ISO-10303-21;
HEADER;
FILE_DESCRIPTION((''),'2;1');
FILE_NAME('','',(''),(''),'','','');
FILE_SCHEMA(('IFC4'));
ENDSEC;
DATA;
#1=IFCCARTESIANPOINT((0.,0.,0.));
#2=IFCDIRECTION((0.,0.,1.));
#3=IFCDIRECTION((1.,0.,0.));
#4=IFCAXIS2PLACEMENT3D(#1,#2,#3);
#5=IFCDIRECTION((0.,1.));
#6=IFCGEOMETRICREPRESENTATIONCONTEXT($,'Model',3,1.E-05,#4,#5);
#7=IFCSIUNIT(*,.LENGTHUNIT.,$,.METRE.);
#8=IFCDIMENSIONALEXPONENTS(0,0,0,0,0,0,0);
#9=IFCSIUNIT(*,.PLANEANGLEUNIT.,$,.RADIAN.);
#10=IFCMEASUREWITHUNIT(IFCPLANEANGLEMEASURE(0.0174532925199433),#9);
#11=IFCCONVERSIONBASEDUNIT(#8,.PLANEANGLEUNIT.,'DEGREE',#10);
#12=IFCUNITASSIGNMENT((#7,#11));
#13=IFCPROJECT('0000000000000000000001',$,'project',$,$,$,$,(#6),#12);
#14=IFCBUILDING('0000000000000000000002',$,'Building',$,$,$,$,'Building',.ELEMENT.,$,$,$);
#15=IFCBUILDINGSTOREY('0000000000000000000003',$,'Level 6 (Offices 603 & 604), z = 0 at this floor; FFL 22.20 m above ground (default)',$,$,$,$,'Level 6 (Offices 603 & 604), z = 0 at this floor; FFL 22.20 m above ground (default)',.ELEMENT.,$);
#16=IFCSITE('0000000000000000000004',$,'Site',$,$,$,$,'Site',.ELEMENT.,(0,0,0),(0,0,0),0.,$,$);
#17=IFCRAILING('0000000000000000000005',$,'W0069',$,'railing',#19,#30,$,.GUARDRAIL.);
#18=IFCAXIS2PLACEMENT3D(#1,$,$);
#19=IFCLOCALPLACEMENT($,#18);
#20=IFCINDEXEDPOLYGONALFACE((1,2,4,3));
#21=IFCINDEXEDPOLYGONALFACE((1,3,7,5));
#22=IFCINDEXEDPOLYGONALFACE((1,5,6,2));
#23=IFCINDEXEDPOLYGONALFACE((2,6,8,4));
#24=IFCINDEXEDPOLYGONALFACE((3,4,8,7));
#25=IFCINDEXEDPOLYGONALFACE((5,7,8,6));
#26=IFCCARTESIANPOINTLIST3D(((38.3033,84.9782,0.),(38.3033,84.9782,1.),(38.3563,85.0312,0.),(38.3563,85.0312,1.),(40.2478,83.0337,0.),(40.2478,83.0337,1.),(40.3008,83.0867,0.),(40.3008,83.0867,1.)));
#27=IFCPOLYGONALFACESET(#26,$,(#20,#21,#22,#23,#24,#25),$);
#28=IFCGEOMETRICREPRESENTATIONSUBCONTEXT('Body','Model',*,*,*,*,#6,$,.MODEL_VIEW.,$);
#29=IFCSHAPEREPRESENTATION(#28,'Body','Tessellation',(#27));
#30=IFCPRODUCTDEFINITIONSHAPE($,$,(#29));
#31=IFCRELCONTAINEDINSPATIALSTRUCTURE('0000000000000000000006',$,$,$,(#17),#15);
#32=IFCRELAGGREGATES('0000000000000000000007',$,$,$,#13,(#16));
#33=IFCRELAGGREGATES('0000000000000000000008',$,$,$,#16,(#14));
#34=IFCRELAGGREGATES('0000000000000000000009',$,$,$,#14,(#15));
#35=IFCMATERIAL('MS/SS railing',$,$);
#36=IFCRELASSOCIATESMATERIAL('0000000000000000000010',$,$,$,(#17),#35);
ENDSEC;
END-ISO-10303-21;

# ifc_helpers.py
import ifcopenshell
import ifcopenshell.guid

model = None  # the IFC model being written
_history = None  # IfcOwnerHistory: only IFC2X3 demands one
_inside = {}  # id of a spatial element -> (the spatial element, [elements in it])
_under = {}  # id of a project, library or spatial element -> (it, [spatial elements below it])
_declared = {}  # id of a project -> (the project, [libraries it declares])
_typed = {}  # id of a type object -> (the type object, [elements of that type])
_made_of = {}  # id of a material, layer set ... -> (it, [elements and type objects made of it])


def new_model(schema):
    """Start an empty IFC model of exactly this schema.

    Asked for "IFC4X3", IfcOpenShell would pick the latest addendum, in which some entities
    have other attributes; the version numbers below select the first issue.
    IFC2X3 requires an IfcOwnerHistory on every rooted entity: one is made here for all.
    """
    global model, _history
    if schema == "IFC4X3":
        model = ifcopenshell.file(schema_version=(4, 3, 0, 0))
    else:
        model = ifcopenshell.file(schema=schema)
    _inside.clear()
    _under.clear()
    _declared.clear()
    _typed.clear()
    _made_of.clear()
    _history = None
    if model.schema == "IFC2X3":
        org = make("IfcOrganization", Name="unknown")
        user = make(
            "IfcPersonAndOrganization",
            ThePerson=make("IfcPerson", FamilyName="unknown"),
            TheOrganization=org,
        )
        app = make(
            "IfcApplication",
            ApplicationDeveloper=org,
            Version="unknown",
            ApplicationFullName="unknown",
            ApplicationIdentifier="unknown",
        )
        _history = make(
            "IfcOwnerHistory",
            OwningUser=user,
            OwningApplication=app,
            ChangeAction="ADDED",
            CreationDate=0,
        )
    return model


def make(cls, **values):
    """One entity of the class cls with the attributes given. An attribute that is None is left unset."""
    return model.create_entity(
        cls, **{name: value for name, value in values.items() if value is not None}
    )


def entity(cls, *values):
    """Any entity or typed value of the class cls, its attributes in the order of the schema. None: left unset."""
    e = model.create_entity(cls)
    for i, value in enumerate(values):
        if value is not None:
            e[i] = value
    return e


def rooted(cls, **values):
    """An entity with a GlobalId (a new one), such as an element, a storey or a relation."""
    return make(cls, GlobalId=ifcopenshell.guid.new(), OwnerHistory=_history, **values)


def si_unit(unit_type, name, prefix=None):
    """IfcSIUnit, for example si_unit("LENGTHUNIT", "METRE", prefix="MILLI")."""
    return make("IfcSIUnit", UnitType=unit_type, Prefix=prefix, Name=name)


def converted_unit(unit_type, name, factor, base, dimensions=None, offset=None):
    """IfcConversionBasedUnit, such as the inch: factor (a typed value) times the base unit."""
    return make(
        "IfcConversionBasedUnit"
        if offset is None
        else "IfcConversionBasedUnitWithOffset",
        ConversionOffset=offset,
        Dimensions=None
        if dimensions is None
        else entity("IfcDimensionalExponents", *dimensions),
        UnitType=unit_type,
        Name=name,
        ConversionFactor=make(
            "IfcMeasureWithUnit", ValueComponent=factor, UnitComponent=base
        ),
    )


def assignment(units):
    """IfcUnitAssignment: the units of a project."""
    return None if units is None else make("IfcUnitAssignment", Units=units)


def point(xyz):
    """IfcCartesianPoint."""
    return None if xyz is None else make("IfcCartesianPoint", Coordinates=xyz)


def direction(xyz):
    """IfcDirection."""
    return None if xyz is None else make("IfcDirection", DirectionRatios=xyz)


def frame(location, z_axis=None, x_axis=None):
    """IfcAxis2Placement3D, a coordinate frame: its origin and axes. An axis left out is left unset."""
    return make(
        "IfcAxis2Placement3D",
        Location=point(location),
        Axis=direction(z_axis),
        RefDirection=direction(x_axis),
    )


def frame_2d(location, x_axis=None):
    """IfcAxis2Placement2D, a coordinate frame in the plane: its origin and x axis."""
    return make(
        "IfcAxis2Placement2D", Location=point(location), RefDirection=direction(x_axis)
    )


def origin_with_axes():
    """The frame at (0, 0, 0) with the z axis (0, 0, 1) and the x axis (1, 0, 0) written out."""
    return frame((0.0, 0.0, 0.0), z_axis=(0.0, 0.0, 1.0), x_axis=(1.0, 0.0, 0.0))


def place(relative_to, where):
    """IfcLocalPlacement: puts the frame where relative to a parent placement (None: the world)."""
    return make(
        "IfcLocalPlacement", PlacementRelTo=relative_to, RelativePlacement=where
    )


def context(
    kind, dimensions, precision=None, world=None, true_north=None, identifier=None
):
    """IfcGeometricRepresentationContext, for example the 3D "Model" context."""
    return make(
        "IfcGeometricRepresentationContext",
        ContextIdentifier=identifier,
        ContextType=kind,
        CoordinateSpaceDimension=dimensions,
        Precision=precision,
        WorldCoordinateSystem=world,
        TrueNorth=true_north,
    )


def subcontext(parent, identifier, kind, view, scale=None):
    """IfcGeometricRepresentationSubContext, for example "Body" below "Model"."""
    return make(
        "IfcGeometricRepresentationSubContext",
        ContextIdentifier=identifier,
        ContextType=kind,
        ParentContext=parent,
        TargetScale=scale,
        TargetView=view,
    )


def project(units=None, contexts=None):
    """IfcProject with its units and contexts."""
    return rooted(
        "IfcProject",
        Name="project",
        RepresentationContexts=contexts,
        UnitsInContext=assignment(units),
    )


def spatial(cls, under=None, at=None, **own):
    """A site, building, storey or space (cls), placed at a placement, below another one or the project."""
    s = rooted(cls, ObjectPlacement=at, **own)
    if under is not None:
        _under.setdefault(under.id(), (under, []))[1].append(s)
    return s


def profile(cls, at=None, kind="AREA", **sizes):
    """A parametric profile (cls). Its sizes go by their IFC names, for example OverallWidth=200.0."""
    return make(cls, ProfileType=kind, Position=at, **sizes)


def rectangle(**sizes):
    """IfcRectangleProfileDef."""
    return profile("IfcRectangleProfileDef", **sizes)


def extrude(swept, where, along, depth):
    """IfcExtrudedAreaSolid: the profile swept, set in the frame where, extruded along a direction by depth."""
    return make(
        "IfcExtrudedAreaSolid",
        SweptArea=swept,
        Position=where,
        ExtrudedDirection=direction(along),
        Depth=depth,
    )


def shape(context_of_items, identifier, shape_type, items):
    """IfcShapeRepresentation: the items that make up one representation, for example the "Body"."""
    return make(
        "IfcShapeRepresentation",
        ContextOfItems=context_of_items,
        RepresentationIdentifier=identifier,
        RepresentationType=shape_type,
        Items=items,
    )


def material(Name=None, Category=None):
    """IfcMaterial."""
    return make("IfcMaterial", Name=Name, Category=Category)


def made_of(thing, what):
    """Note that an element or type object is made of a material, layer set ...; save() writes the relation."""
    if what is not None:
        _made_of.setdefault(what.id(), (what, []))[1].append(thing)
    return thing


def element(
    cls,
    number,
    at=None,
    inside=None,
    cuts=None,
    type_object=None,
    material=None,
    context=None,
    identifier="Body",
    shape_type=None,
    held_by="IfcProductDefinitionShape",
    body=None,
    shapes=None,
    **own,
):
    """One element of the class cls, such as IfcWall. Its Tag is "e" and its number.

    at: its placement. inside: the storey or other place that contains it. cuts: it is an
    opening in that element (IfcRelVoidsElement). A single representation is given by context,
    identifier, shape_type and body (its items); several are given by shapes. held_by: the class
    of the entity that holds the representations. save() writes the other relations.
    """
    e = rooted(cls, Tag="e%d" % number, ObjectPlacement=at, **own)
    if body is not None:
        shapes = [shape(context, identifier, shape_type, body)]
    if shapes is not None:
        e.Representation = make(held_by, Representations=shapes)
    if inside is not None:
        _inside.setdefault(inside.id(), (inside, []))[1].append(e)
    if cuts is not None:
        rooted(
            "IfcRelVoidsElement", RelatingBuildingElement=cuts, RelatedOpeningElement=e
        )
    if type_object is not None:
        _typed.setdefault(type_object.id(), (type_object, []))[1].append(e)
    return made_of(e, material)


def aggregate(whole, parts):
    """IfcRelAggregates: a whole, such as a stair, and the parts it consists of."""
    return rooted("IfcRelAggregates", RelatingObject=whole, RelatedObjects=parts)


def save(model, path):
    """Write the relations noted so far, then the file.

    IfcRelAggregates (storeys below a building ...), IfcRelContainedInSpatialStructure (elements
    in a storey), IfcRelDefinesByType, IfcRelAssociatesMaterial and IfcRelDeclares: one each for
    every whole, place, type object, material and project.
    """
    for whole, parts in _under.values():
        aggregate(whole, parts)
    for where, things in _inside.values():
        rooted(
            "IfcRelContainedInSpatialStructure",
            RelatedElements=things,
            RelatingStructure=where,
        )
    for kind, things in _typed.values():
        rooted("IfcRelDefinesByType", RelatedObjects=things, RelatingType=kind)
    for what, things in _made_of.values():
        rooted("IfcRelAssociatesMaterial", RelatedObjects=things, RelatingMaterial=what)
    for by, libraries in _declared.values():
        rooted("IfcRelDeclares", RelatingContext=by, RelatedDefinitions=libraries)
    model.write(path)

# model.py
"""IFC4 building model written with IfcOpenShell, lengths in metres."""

from ifc_helpers import new_model, entity, si_unit, converted_unit, direction, frame, frame_2d, origin_with_axes, place, context, subcontext, project, spatial, rectangle, extrude, material, element, save


model = new_model("IFC4")

# Units and contexts
model_context = context("Model", 3, precision=1e-05, world=origin_with_axes(), true_north=direction((0.0, 1.0)))
body_context = subcontext(model_context, "Body", "Model", "MODEL_VIEW")
ifc_project = project(units=[si_unit("LENGTHUNIT", "METRE"), converted_unit("PLANEANGLEUNIT", "DEGREE", entity("IfcPlaneAngleMeasure", 0.0174532925199433), si_unit("PLANEANGLEUNIT", "RADIAN"), dimensions=[0, 0, 0, 0, 0, 0, 0])], contexts=[model_context])

# Site, building, storey
site = spatial("IfcSite", under=ifc_project, Name="Site", LongName="Site", CompositionType="ELEMENT", RefLatitude=(0, 0, 0), RefLongitude=(0, 0, 0), RefElevation=0.0)
building = spatial("IfcBuilding", under=site, Name="Building", LongName="Building", CompositionType="ELEMENT")
storey = spatial("IfcBuildingStorey", under=building, Name="Level 6 (Offices 603 & 604), z = 0 at this floor; FFL 22.20 m above ground (default)", LongName="Level 6 (Offices 603 & 604), z = 0 at this floor; FFL 22.20 m above ground (default)", CompositionType="ELEMENT")

# Shared definitions
placement = place(None, origin_with_axes())

# Railing
ifc_material_1 = material(Name="MS/SS railing")
element("IfcRailing", 1, at=placement, inside=storey, material=ifc_material_1, Name="W0069", ObjectType="railing", PredefinedType="GUARDRAIL", context=body_context, shape_type="SweptSolid", body=[
    extrude(rectangle(XDim=2.7499, YDim=0.075, at=frame_2d((0.0, 0.0), x_axis=(0.707107, -0.707107))), frame((39.3021, 84.0324, 0.0), z_axis=(0.0, 0.0, 1.0), x_axis=(1.0, 0.0, 0.0)), (0.0, 0.0, 1.0), 1.0),
])

save(model, "model.ifc")
